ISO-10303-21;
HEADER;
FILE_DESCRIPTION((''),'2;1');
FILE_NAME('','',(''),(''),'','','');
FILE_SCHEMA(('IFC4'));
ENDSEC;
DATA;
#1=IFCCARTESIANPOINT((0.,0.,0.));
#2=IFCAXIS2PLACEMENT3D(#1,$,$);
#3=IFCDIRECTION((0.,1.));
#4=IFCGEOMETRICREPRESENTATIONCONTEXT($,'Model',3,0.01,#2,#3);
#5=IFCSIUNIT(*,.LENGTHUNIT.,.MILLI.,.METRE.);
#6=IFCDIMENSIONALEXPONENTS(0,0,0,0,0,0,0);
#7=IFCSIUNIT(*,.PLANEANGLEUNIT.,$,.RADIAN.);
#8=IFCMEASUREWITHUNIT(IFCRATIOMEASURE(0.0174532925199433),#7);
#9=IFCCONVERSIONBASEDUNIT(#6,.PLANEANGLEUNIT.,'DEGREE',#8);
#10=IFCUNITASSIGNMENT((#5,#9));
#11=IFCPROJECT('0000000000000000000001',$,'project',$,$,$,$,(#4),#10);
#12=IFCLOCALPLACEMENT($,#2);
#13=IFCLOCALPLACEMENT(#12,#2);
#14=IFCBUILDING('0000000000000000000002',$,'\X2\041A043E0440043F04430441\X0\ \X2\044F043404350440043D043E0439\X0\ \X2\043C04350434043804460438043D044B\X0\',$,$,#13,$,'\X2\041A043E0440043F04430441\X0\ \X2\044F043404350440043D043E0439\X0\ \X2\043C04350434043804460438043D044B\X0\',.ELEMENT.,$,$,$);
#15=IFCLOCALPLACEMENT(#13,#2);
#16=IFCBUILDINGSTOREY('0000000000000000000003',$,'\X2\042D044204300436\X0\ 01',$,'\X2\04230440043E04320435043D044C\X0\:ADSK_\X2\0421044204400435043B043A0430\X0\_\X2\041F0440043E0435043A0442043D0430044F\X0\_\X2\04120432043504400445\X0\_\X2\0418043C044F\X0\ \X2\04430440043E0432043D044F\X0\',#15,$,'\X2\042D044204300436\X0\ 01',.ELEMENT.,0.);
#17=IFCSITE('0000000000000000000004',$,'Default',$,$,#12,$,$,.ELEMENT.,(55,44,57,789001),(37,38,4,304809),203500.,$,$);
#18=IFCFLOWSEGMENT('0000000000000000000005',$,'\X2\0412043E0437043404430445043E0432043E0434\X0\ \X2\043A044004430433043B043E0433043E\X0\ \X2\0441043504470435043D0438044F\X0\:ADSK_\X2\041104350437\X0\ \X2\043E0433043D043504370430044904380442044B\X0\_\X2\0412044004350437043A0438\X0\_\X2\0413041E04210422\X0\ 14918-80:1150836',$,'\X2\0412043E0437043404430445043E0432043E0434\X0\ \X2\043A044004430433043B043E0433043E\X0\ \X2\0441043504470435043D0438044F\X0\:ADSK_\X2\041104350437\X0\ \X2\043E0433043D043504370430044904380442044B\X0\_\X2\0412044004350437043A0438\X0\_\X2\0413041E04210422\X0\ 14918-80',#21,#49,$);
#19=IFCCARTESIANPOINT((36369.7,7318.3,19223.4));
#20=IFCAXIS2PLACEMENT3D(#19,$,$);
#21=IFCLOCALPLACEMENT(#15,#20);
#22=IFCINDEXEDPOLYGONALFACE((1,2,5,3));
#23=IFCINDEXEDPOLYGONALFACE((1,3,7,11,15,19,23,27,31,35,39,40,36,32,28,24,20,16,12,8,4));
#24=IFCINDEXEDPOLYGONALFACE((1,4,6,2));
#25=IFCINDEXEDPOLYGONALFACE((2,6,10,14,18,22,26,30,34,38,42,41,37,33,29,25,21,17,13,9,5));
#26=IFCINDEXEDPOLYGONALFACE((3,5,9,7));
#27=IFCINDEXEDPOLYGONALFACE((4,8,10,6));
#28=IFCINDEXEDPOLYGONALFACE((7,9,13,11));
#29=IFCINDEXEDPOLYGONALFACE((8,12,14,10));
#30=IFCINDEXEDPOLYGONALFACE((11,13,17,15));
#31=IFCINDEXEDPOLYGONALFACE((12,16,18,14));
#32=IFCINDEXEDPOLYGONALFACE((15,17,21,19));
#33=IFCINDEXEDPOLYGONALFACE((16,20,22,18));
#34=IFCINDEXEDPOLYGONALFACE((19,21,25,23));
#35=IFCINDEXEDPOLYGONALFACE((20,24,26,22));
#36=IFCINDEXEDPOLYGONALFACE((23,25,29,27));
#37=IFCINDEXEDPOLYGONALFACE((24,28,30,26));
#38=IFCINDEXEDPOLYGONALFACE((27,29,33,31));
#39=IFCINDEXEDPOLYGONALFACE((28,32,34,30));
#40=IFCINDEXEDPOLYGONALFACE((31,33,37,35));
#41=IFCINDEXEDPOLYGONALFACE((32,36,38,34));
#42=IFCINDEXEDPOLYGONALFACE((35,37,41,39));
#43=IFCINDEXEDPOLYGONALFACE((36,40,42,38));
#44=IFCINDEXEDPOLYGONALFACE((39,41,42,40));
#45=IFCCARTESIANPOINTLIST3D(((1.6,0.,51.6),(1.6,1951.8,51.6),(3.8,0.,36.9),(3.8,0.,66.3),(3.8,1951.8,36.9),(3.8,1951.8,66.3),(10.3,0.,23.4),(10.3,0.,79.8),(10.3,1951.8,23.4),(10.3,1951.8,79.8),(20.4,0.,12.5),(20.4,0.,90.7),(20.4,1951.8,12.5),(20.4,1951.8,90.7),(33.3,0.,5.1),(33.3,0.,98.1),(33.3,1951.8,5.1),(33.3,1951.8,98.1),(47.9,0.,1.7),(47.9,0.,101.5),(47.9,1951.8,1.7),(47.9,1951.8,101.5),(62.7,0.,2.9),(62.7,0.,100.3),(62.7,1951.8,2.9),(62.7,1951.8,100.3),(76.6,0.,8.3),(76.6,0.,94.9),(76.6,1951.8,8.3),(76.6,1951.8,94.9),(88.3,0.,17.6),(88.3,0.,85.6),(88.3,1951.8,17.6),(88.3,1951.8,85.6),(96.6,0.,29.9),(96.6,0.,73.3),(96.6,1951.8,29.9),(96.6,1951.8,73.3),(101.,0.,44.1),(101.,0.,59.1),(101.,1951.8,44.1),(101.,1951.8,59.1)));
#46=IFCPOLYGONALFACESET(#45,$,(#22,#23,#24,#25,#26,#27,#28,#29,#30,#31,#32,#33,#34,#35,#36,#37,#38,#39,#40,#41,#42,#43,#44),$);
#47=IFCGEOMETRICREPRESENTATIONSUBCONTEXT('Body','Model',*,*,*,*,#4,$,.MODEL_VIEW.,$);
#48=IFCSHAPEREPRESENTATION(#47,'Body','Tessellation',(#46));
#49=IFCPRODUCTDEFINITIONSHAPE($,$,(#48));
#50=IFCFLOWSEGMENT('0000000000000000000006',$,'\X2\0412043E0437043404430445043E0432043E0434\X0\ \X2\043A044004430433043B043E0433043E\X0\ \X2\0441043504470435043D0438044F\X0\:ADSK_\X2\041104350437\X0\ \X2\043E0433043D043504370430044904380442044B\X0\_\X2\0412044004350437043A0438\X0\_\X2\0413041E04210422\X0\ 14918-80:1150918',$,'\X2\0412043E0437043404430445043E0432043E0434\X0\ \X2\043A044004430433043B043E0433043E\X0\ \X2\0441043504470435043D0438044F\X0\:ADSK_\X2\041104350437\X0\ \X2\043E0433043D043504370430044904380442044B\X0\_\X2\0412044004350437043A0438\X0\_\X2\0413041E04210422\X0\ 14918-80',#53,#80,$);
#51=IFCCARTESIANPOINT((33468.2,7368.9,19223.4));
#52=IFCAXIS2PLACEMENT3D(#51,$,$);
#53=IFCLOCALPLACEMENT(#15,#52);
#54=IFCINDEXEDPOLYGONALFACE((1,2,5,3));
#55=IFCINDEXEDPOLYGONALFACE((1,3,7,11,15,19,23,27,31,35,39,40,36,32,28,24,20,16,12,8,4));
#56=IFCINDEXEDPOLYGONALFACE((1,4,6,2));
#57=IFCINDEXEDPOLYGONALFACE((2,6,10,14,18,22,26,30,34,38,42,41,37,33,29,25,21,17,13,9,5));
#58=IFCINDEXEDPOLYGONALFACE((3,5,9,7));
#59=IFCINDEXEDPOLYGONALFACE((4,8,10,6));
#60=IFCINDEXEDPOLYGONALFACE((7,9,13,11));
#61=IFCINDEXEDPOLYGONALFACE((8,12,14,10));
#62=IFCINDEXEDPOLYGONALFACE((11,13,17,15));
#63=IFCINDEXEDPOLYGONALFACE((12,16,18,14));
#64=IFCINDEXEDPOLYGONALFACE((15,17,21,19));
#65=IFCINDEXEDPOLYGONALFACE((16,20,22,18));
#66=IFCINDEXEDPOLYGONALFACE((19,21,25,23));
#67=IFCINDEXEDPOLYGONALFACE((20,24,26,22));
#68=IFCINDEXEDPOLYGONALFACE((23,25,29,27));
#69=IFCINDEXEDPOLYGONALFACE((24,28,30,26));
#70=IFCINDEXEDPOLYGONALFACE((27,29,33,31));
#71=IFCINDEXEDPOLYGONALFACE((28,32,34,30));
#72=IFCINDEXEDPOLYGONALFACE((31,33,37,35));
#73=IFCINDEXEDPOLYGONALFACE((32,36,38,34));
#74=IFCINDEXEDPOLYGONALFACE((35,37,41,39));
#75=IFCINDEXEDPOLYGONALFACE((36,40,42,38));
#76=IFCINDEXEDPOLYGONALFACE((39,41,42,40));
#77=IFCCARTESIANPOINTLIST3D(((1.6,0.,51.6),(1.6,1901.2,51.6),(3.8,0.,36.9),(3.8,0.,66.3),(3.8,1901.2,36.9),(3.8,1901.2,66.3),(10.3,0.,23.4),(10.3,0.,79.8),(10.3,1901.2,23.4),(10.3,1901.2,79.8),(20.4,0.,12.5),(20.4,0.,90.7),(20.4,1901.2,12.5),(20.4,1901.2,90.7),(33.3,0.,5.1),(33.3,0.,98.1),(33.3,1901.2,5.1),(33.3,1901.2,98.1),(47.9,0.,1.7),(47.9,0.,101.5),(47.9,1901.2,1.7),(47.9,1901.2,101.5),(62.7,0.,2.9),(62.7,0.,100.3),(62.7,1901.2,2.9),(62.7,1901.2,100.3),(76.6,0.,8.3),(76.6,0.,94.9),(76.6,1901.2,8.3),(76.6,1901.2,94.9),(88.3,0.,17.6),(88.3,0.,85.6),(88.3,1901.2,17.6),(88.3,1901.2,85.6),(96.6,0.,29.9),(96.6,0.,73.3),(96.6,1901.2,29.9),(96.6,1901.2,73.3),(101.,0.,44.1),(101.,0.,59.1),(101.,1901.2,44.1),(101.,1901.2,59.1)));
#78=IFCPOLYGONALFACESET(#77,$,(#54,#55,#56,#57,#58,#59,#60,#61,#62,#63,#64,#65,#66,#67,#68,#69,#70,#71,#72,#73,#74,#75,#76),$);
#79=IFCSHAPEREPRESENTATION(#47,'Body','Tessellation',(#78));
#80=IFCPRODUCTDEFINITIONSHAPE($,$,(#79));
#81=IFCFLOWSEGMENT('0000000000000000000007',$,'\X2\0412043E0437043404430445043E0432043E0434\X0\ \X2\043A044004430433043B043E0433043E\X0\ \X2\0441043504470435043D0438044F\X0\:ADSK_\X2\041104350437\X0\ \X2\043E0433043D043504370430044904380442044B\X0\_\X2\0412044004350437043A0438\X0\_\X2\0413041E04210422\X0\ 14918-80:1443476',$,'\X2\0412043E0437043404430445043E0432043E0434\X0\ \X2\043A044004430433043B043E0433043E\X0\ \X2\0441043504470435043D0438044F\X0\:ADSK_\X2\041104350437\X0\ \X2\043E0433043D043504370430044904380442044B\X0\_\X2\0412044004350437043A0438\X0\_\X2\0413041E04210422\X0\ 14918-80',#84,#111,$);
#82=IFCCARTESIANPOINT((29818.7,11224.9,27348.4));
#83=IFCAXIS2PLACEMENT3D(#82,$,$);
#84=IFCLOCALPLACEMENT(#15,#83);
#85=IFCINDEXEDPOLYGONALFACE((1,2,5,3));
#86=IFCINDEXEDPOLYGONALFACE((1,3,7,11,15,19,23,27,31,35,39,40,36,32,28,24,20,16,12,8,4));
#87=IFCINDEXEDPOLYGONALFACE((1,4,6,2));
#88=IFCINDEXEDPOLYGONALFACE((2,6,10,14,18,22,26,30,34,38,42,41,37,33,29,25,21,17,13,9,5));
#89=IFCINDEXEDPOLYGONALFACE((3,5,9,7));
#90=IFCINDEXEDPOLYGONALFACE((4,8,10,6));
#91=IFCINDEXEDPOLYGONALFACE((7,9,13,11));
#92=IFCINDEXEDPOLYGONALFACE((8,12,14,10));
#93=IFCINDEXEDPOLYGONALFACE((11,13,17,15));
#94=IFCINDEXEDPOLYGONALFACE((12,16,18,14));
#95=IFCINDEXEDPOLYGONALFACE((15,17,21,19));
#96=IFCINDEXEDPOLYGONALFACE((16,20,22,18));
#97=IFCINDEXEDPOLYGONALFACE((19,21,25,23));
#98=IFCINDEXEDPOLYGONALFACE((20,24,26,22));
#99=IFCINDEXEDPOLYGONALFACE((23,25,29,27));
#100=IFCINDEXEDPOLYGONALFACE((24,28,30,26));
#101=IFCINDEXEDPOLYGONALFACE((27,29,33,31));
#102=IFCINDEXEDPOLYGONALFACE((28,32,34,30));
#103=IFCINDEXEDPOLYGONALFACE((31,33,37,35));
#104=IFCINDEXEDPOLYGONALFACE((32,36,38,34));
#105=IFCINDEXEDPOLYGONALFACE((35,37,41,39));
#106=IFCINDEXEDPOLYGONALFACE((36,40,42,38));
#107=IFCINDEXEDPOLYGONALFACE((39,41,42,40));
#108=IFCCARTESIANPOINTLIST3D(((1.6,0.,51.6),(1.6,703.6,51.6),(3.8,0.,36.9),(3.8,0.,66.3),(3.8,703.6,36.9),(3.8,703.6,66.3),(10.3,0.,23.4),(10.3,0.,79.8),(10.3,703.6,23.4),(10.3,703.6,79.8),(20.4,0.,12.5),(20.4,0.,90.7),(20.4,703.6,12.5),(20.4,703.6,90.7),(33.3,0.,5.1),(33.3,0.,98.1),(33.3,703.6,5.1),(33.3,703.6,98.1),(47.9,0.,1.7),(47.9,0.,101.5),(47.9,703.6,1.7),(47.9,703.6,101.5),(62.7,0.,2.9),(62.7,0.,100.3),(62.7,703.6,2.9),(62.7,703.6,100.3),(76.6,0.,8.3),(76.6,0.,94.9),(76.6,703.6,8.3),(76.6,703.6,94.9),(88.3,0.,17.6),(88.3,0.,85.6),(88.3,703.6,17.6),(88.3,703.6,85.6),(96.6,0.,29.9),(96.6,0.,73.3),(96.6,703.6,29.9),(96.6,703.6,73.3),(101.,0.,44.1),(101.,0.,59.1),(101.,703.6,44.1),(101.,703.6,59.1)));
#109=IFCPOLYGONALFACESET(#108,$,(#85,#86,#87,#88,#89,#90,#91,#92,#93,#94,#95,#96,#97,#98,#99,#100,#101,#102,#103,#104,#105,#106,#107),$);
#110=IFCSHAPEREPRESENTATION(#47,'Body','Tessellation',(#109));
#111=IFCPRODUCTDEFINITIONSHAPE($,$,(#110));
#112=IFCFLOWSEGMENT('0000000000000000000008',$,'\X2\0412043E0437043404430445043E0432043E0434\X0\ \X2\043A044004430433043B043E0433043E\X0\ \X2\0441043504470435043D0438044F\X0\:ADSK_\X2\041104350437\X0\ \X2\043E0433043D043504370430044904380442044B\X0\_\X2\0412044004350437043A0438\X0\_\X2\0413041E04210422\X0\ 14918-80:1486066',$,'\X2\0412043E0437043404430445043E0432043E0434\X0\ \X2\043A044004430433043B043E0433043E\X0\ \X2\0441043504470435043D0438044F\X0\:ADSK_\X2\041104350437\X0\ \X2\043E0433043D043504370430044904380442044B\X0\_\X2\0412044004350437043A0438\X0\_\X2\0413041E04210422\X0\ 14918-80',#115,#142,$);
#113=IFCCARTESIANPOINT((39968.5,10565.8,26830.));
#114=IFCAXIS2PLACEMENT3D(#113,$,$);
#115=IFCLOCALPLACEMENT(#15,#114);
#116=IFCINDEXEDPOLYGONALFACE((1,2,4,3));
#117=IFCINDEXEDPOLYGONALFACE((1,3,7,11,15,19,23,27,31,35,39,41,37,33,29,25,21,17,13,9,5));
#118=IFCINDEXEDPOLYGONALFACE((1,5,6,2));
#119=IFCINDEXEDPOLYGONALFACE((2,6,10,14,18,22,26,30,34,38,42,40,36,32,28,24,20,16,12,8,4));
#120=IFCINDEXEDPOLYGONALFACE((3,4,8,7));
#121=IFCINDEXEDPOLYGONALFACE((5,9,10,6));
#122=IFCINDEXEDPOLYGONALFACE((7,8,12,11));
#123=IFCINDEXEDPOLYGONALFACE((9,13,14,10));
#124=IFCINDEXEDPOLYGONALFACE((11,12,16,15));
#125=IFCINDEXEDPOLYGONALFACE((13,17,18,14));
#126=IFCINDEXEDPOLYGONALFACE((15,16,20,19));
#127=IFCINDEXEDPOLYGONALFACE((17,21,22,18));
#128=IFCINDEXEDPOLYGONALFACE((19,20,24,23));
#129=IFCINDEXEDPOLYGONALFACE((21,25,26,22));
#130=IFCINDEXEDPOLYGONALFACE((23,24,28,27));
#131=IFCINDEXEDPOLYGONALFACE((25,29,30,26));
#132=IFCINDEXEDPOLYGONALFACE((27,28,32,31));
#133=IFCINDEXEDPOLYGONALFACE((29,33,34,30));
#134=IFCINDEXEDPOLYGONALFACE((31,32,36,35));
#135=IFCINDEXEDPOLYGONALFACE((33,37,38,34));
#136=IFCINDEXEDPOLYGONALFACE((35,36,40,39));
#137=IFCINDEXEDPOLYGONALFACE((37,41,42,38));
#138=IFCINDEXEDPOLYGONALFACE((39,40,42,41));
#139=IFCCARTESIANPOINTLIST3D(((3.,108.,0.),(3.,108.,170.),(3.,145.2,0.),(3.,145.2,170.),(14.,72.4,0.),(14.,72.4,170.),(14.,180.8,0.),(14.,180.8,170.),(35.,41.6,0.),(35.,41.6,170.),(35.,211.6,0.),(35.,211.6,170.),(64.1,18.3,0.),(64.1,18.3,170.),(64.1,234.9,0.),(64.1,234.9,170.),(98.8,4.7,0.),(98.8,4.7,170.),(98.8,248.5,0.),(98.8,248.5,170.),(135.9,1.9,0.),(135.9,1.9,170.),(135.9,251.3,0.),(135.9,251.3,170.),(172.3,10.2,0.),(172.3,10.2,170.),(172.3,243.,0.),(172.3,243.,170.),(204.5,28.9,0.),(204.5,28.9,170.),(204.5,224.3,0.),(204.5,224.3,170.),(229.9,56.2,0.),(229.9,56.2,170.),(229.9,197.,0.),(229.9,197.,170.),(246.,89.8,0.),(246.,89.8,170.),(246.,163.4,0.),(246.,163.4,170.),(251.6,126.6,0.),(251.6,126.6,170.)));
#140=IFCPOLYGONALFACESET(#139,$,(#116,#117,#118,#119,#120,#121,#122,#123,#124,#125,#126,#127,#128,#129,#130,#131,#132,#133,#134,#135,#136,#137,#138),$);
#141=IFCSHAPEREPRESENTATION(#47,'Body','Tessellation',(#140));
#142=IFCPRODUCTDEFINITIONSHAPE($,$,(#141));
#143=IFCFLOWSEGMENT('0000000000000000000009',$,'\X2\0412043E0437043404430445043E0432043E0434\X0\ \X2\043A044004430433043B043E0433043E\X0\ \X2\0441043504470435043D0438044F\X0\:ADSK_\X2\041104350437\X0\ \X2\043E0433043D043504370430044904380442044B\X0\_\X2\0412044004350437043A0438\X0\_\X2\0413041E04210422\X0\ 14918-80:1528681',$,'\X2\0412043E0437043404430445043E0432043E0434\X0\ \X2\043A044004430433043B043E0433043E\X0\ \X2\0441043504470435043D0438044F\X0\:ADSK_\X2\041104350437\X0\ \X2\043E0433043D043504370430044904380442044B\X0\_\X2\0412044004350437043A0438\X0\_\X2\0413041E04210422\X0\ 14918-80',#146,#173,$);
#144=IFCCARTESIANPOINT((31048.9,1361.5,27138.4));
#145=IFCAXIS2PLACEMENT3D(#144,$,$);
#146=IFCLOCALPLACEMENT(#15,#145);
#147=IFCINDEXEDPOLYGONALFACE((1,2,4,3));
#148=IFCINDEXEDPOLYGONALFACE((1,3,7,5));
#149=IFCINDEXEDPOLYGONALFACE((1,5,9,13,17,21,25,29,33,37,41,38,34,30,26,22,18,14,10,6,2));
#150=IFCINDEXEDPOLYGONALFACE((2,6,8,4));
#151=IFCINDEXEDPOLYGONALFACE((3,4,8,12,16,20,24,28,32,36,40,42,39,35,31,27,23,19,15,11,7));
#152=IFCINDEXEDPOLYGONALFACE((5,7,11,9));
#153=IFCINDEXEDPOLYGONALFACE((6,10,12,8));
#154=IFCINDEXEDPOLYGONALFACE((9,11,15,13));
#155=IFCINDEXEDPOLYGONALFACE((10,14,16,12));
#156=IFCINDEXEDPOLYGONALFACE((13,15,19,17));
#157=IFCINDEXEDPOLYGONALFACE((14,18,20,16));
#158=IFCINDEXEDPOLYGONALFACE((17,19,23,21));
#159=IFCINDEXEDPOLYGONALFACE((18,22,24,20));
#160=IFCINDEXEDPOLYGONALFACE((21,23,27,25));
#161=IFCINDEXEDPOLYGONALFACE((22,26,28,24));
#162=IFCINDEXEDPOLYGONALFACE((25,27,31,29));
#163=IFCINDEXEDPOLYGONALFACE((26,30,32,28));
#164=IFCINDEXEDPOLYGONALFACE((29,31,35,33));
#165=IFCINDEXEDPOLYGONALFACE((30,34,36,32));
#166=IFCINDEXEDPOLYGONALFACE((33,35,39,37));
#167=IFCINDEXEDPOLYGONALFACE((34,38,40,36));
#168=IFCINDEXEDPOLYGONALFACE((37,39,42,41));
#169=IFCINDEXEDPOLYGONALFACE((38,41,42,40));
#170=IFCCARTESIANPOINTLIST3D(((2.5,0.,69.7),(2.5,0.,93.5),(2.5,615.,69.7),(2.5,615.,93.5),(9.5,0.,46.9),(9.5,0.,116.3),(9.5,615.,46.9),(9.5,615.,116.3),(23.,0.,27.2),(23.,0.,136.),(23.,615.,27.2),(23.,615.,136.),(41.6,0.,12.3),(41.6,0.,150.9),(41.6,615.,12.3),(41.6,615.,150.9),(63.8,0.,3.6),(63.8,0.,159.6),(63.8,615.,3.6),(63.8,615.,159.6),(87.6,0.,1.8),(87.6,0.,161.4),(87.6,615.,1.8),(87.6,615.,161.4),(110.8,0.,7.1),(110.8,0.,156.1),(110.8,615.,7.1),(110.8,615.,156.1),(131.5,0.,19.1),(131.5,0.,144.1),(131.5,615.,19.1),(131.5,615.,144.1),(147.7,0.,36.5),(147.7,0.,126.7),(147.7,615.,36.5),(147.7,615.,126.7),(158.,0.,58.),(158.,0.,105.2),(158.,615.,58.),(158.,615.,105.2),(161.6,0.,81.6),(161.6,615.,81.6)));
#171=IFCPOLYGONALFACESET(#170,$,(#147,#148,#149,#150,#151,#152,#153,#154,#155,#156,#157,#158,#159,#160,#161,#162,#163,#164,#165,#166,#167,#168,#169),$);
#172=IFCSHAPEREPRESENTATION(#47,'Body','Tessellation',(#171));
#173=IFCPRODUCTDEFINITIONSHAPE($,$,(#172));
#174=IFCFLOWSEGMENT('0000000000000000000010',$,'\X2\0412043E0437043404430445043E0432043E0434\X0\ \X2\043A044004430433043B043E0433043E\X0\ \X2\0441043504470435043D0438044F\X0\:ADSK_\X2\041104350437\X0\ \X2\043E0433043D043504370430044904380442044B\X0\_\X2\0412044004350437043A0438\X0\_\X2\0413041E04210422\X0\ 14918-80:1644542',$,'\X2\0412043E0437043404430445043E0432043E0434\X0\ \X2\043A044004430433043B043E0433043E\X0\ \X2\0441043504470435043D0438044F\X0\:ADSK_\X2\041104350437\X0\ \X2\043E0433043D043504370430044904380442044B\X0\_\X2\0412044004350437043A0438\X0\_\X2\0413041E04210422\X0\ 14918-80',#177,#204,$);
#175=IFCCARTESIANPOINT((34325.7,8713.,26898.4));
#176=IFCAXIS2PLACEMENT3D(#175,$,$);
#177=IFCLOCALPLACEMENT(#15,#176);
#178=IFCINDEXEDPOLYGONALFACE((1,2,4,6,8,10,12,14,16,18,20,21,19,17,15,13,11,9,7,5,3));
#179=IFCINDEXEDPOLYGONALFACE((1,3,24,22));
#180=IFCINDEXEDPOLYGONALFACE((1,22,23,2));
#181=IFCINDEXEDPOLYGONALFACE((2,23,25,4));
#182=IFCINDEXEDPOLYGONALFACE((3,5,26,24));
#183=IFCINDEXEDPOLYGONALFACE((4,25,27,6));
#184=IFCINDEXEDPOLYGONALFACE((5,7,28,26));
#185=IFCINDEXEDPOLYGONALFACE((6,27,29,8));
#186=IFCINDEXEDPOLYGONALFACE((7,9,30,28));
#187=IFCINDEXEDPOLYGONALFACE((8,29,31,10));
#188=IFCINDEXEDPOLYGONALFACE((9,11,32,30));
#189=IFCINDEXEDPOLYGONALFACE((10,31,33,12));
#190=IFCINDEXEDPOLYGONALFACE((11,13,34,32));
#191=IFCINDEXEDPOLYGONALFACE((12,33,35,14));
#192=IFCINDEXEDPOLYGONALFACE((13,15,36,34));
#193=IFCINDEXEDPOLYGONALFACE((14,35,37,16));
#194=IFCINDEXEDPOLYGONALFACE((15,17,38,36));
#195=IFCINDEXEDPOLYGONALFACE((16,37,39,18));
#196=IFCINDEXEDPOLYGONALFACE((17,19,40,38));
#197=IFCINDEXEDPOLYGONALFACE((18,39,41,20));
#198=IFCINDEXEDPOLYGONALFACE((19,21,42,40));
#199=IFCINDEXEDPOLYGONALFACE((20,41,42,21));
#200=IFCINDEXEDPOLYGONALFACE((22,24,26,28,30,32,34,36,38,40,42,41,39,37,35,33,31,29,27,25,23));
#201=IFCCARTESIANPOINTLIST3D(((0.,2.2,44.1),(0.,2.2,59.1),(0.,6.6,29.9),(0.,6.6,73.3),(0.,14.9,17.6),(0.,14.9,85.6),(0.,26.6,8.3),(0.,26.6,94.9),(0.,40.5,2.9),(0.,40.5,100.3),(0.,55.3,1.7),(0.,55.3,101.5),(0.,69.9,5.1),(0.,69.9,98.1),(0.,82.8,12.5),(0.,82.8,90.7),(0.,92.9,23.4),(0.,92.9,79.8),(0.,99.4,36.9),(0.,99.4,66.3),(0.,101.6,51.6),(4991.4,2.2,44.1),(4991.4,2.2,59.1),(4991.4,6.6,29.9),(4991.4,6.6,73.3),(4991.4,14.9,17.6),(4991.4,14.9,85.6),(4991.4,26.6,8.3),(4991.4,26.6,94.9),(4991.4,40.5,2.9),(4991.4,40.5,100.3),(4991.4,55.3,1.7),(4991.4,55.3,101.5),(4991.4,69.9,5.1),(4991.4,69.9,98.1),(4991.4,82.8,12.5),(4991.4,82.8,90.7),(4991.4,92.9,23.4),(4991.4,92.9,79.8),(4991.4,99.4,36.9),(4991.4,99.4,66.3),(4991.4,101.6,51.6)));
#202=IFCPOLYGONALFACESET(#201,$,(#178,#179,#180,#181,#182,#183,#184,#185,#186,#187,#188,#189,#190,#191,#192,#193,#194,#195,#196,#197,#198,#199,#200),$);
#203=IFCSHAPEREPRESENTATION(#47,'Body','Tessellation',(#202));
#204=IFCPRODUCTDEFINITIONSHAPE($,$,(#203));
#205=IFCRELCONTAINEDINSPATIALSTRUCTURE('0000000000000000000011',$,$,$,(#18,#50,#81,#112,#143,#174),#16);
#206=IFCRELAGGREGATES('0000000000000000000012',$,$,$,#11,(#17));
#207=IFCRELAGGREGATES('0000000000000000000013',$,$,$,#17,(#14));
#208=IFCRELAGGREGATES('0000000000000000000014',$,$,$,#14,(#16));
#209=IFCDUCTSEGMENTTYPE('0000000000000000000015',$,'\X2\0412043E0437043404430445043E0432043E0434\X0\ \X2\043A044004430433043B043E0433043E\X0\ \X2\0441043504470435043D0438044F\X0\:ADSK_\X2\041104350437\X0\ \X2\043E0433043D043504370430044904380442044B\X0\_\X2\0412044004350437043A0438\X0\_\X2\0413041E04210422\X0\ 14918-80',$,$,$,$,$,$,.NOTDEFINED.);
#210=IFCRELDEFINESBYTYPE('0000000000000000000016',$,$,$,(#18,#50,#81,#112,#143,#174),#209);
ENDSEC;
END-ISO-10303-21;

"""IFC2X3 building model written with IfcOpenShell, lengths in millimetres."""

from ifc_helpers import new_model, entity, si_unit, converted_unit, direction, frame, origin, origin_2d_with_axis, place, context, subcontext, project, spatial, circle, extrude, type_object, element, save


model = new_model("IFC2X3")

# Units and contexts
model_context = context("Model", 3, precision=0.01, world=origin(), true_north=direction((0.0, 1.0)))
body_context = subcontext(model_context, "Body", "Model", "MODEL_VIEW")
ifc_project = project(units=[si_unit("LENGTHUNIT", "METRE", prefix="MILLI"), converted_unit("PLANEANGLEUNIT", "DEGREE", entity("IfcRatioMeasure", 0.0174532925199433), si_unit("PLANEANGLEUNIT", "RADIAN"), dimensions=[0, 0, 0, 0, 0, 0, 0])], contexts=[model_context])

# Site, building, storey
site_placement = place(None, origin())
site = spatial("IfcSite", under=ifc_project, at=site_placement, Name="Default", CompositionType="ELEMENT", RefLatitude=(55, 44, 57, 789001), RefLongitude=(37, 38, 4, 304809), RefElevation=203500.0)
building_placement = place(site_placement, origin())
building = spatial("IfcBuilding", under=site, at=building_placement, Name="Корпус ядерной медицины", LongName="Корпус ядерной медицины", CompositionType="ELEMENT")
storey_placement = place(building_placement, origin())
storey = spatial("IfcBuildingStorey", under=building, at=storey_placement, Name="Этаж 01", ObjectType="Уровень:ADSK_Стрелка_Проектная_Вверх_Имя уровня", LongName="Этаж 01", CompositionType="ELEMENT", Elevation=0.0)

# Flow segments
duct_segment_type_1 = type_object("IfcDuctSegmentType", Name="Воздуховод круглого сечения:ADSK_Без огнезащиты_Врезки_ГОСТ 14918-80", PredefinedType="NOTDEFINED")
flow_segment_1_placement = place(storey_placement, frame((36369.7, 7318.3, 19223.4)))
element("IfcFlowSegment", 1, at=flow_segment_1_placement, inside=storey, type_object=duct_segment_type_1, Name="Воздуховод круглого сечения:ADSK_Без огнезащиты_Врезки_ГОСТ 14918-80:1150836", ObjectType="Воздуховод круглого сечения:ADSK_Без огнезащиты_Врезки_ГОСТ 14918-80", context=body_context, shape_type="SweptSolid", body=[
    extrude(circle(Radius=50.0, at=origin_2d_with_axis()), frame((51.6, 0.0, 51.6), z_axis=(0.0, 1.0, 0.0), x_axis=(-1.0, 0.0, 0.0)), (0.0, 0.0, 1.0), 1951.8),
])
flow_segment_2_placement = place(storey_placement, frame((33468.2, 7368.9, 19223.4)))
element("IfcFlowSegment", 2, at=flow_segment_2_placement, inside=storey, type_object=duct_segment_type_1, Name="Воздуховод круглого сечения:ADSK_Без огнезащиты_Врезки_ГОСТ 14918-80:1150918", ObjectType="Воздуховод круглого сечения:ADSK_Без огнезащиты_Врезки_ГОСТ 14918-80", context=body_context, shape_type="SweptSolid", body=[
    extrude(circle(Radius=50.0, at=origin_2d_with_axis()), frame((51.6, 0.0, 51.6), z_axis=(0.0, 1.0, 0.0), x_axis=(-1.0, 0.0, 0.0)), (0.0, 0.0, 1.0), 1901.2),
])
flow_segment_3_placement = place(storey_placement, frame((29818.7, 11224.9, 27348.4)))
element("IfcFlowSegment", 3, at=flow_segment_3_placement, inside=storey, type_object=duct_segment_type_1, Name="Воздуховод круглого сечения:ADSK_Без огнезащиты_Врезки_ГОСТ 14918-80:1443476", ObjectType="Воздуховод круглого сечения:ADSK_Без огнезащиты_Врезки_ГОСТ 14918-80", context=body_context, shape_type="SweptSolid", body=[
    extrude(circle(Radius=50.0, at=origin_2d_with_axis()), frame((51.6, 0.0, 51.6), z_axis=(0.0, 1.0, 0.0), x_axis=(-1.0, 0.0, 0.0)), (0.0, 0.0, 1.0), 703.6),
])
flow_segment_4_placement = place(storey_placement, frame((39968.5, 10565.8, 26830.0)))
element("IfcFlowSegment", 4, at=flow_segment_4_placement, inside=storey, type_object=duct_segment_type_1, Name="Воздуховод круглого сечения:ADSK_Без огнезащиты_Врезки_ГОСТ 14918-80:1486066", ObjectType="Воздуховод круглого сечения:ADSK_Без огнезащиты_Врезки_ГОСТ 14918-80", context=body_context, shape_type="SweptSolid", body=[
    extrude(circle(Radius=125.0, at=origin_2d_with_axis()), frame((126.6, 126.6, 0.0)), (0.0, 0.0, 1.0), 170.0),
])
flow_segment_5_placement = place(storey_placement, frame((31048.9, 1361.5, 27138.4)))
element("IfcFlowSegment", 5, at=flow_segment_5_placement, inside=storey, type_object=duct_segment_type_1, Name="Воздуховод круглого сечения:ADSK_Без огнезащиты_Врезки_ГОСТ 14918-80:1528681", ObjectType="Воздуховод круглого сечения:ADSK_Без огнезащиты_Врезки_ГОСТ 14918-80", context=body_context, shape_type="SweptSolid", body=[
    extrude(circle(Radius=80.0, at=origin_2d_with_axis()), frame((81.6, 0.0, 81.6), z_axis=(0.0, 1.0, 0.0), x_axis=(1.0, 0.0, 0.0)), (0.0, 0.0, 1.0), 615.0),
])
flow_segment_6_placement = place(storey_placement, frame((34325.7, 8713.0, 26898.4)))
element("IfcFlowSegment", 6, at=flow_segment_6_placement, inside=storey, type_object=duct_segment_type_1, Name="Воздуховод круглого сечения:ADSK_Без огнезащиты_Врезки_ГОСТ 14918-80:1644542", ObjectType="Воздуховод круглого сечения:ADSK_Без огнезащиты_Врезки_ГОСТ 14918-80", context=body_context, shape_type="SweptSolid", body=[
    extrude(circle(Radius=50.0, at=origin_2d_with_axis()), frame((0.0, 51.6, 51.6), z_axis=(1.0, 0.0, 0.0), x_axis=(0.0, 1.0, 0.0)), (0.0, 0.0, 1.0), 4991.4),
])

save(model, "model.ifc")
